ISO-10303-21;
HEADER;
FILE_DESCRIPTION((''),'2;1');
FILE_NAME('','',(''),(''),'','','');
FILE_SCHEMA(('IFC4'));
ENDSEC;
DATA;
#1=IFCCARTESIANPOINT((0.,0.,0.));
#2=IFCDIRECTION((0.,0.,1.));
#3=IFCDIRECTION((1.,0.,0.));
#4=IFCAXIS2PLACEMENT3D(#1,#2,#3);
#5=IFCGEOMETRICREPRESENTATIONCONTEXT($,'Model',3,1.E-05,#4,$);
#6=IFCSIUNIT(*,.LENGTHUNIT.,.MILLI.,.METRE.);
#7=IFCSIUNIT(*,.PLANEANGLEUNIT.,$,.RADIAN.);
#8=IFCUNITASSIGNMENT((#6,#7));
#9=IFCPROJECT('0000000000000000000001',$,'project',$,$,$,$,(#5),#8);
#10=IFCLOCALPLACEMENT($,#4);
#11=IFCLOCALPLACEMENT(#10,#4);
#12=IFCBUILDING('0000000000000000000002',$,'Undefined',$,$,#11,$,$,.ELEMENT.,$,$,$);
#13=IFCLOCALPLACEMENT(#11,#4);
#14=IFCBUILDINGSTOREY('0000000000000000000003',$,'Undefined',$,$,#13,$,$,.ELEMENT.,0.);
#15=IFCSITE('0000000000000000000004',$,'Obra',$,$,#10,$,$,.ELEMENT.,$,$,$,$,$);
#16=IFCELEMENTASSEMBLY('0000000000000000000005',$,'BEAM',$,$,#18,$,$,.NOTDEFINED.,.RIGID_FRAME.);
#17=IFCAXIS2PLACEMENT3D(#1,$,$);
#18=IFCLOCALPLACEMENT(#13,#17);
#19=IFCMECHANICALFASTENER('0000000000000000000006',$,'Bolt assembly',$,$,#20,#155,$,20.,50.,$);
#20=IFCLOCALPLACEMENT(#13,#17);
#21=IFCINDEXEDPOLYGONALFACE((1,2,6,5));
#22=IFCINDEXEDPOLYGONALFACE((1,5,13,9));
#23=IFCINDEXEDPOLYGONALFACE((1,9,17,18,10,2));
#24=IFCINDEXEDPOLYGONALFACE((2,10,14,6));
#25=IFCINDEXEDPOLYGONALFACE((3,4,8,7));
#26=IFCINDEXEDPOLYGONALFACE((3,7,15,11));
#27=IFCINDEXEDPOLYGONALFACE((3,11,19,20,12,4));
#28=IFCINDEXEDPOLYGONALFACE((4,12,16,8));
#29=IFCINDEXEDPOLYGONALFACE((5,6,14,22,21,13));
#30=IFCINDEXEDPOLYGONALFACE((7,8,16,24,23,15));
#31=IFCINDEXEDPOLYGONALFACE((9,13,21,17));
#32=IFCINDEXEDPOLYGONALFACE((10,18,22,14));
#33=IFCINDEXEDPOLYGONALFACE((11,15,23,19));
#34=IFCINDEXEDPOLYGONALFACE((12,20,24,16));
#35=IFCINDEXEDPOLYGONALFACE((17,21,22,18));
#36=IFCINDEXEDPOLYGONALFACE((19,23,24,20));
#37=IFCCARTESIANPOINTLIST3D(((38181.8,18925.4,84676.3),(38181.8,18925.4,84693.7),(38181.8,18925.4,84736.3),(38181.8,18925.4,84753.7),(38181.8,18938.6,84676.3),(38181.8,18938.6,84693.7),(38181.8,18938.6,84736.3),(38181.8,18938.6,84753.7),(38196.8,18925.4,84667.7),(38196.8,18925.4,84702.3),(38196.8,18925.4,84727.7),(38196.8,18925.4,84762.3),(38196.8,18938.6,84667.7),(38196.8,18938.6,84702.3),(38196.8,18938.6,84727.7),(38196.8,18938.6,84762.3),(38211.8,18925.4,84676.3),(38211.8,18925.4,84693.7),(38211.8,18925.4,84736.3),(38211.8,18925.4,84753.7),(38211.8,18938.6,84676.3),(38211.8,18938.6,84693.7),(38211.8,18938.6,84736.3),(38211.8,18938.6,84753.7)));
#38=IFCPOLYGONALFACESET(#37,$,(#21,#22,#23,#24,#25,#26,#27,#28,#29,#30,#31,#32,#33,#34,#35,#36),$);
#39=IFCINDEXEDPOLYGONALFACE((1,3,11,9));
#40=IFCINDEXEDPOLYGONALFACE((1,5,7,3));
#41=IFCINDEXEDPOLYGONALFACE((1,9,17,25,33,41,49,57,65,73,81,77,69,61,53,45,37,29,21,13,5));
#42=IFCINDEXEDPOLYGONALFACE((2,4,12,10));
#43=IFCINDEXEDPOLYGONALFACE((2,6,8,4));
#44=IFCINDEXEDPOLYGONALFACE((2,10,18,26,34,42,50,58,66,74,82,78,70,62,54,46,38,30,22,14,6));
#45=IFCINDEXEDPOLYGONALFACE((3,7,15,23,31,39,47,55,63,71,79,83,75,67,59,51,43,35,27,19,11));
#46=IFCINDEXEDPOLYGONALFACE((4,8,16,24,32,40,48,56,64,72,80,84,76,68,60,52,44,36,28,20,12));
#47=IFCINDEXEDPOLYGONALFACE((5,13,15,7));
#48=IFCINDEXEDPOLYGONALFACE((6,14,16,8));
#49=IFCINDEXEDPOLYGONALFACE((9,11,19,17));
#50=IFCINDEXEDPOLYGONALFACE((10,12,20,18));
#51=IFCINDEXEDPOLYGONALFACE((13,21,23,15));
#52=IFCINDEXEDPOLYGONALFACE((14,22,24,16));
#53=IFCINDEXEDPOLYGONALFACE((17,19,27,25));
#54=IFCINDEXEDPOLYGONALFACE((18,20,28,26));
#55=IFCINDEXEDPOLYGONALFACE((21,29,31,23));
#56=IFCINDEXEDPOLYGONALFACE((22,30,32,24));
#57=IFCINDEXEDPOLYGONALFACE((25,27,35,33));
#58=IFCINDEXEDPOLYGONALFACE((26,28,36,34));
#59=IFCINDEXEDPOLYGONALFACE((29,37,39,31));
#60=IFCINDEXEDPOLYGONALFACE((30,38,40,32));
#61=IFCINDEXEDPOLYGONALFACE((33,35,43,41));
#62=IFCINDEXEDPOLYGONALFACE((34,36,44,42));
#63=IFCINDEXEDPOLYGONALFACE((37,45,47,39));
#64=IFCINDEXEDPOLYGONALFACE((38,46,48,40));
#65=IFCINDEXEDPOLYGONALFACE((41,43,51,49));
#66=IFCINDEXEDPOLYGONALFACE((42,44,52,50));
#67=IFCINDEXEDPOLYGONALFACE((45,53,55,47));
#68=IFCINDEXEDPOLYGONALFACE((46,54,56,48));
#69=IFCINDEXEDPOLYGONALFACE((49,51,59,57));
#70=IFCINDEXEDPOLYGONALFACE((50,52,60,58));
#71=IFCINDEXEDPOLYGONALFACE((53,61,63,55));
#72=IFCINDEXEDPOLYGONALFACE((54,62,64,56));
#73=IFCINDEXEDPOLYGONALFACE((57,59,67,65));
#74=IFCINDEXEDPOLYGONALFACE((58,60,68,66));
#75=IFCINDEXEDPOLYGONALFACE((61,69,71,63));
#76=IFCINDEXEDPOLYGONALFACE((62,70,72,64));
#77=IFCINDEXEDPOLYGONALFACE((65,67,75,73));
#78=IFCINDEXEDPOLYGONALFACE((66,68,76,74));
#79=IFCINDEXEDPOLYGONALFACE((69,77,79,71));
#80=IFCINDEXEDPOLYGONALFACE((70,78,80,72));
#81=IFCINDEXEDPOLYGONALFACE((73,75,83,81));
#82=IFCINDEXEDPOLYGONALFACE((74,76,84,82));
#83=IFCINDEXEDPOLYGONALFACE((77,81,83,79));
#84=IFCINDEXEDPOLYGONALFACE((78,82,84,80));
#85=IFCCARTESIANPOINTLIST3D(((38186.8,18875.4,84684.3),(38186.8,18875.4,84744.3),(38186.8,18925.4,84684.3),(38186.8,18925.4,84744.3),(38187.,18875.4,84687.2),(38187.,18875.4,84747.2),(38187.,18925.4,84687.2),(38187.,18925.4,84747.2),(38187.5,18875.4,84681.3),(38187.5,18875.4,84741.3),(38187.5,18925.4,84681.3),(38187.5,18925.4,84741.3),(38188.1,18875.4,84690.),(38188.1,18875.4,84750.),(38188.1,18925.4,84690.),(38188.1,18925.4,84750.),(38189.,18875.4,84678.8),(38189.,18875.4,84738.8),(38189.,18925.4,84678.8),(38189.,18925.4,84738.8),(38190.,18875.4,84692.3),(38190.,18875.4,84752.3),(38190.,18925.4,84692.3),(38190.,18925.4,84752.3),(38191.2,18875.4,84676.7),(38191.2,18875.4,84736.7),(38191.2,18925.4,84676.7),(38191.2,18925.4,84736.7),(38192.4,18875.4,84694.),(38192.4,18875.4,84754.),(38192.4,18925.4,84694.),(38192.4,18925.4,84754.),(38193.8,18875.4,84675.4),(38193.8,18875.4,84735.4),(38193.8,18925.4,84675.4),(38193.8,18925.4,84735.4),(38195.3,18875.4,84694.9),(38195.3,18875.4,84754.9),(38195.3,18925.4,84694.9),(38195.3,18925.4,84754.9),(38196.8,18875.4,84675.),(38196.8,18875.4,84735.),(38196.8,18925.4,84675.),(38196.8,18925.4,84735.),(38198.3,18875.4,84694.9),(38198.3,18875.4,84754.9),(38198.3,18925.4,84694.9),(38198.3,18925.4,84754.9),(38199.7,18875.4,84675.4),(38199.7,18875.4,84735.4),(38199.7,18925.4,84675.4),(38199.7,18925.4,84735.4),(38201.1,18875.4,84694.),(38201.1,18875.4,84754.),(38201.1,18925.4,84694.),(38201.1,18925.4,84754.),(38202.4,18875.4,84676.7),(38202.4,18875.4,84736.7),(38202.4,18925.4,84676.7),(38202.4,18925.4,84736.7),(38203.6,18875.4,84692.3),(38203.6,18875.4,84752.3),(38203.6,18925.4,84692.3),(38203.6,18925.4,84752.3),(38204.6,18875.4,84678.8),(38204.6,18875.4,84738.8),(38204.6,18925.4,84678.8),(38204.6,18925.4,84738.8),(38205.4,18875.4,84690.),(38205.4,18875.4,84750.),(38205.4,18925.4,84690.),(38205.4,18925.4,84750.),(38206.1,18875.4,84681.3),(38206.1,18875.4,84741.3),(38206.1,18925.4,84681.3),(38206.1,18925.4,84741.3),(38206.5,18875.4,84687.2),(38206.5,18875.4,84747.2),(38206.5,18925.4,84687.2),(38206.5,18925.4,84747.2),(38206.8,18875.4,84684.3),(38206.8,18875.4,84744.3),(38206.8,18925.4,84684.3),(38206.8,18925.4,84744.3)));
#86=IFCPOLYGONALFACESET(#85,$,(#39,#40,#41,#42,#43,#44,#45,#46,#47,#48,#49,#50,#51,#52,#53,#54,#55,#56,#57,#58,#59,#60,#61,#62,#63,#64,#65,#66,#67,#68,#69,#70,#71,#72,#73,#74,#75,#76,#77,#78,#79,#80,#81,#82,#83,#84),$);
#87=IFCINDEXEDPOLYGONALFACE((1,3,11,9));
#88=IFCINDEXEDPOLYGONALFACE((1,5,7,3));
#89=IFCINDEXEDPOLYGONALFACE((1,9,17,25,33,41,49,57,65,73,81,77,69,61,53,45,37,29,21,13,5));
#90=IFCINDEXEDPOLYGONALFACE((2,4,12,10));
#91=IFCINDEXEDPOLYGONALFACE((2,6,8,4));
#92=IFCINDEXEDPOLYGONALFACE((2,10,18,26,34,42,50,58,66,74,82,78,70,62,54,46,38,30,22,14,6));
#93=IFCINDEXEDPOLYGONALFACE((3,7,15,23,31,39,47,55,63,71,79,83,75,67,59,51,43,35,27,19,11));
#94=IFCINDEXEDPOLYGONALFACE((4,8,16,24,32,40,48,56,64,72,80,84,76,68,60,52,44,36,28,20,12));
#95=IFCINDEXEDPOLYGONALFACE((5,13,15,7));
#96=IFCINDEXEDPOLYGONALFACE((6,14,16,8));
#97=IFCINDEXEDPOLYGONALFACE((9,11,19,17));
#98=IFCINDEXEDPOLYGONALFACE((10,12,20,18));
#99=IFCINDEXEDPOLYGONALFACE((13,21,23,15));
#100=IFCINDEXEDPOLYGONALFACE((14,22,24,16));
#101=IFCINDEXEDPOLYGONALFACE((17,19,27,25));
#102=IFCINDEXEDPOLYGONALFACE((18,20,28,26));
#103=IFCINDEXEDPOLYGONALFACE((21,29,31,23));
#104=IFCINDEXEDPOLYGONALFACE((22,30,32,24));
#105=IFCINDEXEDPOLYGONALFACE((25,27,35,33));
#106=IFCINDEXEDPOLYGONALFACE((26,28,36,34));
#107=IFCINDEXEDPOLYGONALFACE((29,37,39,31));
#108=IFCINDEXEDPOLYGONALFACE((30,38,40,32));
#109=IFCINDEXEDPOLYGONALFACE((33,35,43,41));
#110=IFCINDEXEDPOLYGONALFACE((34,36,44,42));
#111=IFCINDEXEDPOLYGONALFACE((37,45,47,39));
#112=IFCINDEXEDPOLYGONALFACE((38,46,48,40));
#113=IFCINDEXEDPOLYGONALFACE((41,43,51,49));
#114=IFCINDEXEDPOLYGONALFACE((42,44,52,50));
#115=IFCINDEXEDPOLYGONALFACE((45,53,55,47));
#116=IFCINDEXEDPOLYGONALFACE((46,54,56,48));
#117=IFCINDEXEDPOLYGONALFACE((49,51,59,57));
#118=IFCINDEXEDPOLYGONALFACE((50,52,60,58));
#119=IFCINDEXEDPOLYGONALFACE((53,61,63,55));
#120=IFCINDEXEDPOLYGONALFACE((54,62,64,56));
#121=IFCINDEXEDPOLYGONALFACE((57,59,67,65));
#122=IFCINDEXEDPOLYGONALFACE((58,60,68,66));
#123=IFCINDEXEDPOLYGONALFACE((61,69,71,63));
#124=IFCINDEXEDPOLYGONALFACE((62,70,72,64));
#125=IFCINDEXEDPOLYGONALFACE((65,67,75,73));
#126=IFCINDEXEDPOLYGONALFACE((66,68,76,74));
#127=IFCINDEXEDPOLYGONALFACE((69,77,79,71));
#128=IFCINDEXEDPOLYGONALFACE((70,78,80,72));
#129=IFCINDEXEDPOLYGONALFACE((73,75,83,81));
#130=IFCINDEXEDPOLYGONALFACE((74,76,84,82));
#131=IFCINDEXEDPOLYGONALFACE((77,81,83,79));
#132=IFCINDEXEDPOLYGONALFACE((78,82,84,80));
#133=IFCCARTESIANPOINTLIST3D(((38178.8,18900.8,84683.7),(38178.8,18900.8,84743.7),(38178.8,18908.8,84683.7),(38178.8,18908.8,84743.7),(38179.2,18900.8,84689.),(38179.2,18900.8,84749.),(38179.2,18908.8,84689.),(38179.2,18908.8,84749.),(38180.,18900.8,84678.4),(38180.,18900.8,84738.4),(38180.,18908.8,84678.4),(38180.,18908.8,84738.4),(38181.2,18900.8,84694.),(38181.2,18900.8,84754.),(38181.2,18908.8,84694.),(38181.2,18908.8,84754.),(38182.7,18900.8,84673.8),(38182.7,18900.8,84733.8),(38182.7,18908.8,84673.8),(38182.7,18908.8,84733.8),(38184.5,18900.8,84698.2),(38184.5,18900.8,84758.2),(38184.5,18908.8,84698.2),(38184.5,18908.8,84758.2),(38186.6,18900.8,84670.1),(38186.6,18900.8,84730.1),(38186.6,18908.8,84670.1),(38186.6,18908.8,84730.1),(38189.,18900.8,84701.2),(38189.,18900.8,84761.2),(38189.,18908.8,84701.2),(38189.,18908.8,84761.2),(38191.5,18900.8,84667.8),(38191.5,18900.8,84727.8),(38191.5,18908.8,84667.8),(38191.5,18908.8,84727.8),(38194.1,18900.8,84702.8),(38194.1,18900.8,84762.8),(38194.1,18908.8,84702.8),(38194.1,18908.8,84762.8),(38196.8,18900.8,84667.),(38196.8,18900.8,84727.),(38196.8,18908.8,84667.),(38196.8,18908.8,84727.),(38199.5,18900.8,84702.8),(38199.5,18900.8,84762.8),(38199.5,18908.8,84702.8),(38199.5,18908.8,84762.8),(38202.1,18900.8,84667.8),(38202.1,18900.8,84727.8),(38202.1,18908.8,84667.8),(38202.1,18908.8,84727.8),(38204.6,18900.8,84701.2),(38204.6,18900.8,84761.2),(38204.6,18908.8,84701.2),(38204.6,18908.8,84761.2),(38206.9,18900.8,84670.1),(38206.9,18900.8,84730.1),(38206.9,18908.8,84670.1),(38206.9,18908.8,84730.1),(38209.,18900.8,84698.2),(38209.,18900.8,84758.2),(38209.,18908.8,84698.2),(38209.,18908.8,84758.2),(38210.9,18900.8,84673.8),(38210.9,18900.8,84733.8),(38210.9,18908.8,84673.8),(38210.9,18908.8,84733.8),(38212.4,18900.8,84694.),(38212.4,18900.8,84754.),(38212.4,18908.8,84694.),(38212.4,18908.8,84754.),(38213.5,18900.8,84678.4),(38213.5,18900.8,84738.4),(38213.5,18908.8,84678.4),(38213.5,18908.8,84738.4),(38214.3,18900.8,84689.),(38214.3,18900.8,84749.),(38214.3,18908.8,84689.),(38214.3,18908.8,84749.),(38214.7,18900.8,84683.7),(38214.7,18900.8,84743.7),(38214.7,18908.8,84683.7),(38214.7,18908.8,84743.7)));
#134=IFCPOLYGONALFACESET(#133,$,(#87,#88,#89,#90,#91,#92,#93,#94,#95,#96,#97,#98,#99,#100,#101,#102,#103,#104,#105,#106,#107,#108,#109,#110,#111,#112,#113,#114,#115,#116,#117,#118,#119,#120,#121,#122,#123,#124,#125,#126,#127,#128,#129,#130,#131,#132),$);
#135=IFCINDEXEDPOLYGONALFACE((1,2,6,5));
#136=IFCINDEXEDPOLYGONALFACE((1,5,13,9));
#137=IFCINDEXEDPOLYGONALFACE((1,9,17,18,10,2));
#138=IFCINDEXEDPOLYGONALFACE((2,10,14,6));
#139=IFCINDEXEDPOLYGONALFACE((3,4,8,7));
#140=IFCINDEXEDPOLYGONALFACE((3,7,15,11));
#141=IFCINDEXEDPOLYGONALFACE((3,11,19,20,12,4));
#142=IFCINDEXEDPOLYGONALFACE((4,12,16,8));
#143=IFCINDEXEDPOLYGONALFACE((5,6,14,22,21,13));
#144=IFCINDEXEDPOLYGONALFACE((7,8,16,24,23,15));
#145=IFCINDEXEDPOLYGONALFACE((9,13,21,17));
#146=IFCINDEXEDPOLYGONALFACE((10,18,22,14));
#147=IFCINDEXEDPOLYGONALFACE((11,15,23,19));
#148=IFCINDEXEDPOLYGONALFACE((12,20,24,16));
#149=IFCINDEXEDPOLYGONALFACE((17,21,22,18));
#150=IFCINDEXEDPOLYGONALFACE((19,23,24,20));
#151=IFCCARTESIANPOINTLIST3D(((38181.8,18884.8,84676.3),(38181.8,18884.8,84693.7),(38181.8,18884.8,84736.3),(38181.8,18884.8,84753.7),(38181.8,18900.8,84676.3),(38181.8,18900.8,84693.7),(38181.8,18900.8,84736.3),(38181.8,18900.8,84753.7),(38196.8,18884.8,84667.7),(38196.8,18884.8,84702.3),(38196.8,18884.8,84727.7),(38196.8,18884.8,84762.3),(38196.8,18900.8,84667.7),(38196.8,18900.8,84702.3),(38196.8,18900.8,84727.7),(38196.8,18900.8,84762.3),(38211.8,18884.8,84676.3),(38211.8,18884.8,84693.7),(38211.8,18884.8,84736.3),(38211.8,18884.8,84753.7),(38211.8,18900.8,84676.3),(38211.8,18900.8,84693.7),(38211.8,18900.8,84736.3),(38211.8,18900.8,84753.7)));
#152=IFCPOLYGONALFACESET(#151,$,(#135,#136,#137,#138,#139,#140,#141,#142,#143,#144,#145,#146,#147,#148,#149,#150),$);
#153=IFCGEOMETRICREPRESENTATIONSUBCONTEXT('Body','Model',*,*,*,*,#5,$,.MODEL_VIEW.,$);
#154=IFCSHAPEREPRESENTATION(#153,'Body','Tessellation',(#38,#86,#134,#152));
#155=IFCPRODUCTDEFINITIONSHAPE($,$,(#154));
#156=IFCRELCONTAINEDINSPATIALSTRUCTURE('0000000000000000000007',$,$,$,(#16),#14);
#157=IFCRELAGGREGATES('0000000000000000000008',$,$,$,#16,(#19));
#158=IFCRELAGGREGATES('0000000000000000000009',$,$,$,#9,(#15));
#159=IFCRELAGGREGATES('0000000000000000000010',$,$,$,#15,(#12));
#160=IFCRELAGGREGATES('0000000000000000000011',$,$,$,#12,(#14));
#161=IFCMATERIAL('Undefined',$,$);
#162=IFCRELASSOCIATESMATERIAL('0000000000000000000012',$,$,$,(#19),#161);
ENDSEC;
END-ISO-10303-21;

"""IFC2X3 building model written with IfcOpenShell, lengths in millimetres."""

from ifc_helpers import new_model, si_unit, frame, origin_with_axes, origin_2d_with_axis, place, context, subcontext, project, spatial, polyline, circle, outline, extrude, source, transform, mapped, material, element, aggregate, save


model = new_model("IFC2X3")

# Units and contexts
model_context = context("Model", 3, precision=1e-05, world=origin_with_axes())
body_context = subcontext(model_context, "Body", "Model", "MODEL_VIEW")
ifc_project = project(units=[si_unit("LENGTHUNIT", "METRE", prefix="MILLI"), si_unit("PLANEANGLEUNIT", "RADIAN")], contexts=[model_context])

# Site, building, storey
site_placement = place(None, origin_with_axes())
site = spatial("IfcSite", under=ifc_project, at=site_placement, Name="Obra", CompositionType="ELEMENT")
building_placement = place(site_placement, origin_with_axes())
building = spatial("IfcBuilding", under=site, at=building_placement, Name="Undefined", CompositionType="ELEMENT")
storey_placement = place(building_placement, origin_with_axes())
storey = spatial("IfcBuildingStorey", under=building, at=storey_placement, Name="Undefined", CompositionType="ELEMENT", Elevation=0.0)

# Shared definitions
ifc_material_1 = material(Name="Undefined")

# Element assembly, mechanical fastener
shared_shape_1 = source(origin_with_axes(), body_context, "Body", "SweptSolid", [
    extrude(outline(polyline([(17.3, 0.0), (8.7, 15.0), (-8.7, 15.0), (-17.3, 0.0), (-8.7, -15.0), (8.7, -15.0), (17.3, 0.0)])), frame((0.0, -26.5, 0.0), z_axis=(0.0, 1.0, 0.0), x_axis=(1.0, 0.0, 0.0)), (0.0, 0.0, 1.0), 13.2),
    extrude(circle(Radius=10.0, at=origin_2d_with_axis()), frame((0.0, -13.3, 0.0), z_axis=(0.0, 1.0, 0.0), x_axis=(1.0, 0.0, 0.0)), (0.0, 0.0, 1.0), 50.0),
    extrude(circle(Radius=18.0, at=origin_2d_with_axis()), frame((0.0, 3.3, 0.0), z_axis=(0.0, 1.0, 0.0), x_axis=(1.0, 0.0, 0.0)), (0.0, 0.0, 1.0), 8.0),
    extrude(outline(polyline([(17.3, 0.0), (8.7, 15.0), (-8.7, 15.0), (-17.3, 0.0), (-8.7, -15.0), (8.7, -15.0), (17.3, 0.0)])), frame((0.0, 11.3, 0.0), z_axis=(0.0, 1.0, 0.0), x_axis=(1.0, 0.0, 0.0)), (0.0, 0.0, 1.0), 16.0),
])
assembly_1_placement = place(storey_placement, origin_with_axes())
assembly_1 = element("IfcElementAssembly", 1, at=assembly_1_placement, inside=storey, Name="BEAM", AssemblyPlace="NOTDEFINED", PredefinedType="RIGID_FRAME")
mechanical_fastener_1_placement = place(assembly_1_placement, frame((38236.8, 18912.1, 84850.0), z_axis=(-1.0, 0.0, 0.0), x_axis=(0.0, 0.0, -1.0)))
mechanical_fastener_1 = element("IfcMechanicalFastener", 2, at=mechanical_fastener_1_placement, material=ifc_material_1, Name="Bolt assembly", NominalDiameter=20.0, NominalLength=50.0, context=body_context, shape_type="MappedRepresentation", body=[
    mapped(shared_shape_1, transform((105.0, 0.0, 40.0))),
    mapped(shared_shape_1, transform((165.0, 0.0, 40.0))),
])
aggregate(assembly_1, [mechanical_fastener_1])

save(model, "model.ifc")
